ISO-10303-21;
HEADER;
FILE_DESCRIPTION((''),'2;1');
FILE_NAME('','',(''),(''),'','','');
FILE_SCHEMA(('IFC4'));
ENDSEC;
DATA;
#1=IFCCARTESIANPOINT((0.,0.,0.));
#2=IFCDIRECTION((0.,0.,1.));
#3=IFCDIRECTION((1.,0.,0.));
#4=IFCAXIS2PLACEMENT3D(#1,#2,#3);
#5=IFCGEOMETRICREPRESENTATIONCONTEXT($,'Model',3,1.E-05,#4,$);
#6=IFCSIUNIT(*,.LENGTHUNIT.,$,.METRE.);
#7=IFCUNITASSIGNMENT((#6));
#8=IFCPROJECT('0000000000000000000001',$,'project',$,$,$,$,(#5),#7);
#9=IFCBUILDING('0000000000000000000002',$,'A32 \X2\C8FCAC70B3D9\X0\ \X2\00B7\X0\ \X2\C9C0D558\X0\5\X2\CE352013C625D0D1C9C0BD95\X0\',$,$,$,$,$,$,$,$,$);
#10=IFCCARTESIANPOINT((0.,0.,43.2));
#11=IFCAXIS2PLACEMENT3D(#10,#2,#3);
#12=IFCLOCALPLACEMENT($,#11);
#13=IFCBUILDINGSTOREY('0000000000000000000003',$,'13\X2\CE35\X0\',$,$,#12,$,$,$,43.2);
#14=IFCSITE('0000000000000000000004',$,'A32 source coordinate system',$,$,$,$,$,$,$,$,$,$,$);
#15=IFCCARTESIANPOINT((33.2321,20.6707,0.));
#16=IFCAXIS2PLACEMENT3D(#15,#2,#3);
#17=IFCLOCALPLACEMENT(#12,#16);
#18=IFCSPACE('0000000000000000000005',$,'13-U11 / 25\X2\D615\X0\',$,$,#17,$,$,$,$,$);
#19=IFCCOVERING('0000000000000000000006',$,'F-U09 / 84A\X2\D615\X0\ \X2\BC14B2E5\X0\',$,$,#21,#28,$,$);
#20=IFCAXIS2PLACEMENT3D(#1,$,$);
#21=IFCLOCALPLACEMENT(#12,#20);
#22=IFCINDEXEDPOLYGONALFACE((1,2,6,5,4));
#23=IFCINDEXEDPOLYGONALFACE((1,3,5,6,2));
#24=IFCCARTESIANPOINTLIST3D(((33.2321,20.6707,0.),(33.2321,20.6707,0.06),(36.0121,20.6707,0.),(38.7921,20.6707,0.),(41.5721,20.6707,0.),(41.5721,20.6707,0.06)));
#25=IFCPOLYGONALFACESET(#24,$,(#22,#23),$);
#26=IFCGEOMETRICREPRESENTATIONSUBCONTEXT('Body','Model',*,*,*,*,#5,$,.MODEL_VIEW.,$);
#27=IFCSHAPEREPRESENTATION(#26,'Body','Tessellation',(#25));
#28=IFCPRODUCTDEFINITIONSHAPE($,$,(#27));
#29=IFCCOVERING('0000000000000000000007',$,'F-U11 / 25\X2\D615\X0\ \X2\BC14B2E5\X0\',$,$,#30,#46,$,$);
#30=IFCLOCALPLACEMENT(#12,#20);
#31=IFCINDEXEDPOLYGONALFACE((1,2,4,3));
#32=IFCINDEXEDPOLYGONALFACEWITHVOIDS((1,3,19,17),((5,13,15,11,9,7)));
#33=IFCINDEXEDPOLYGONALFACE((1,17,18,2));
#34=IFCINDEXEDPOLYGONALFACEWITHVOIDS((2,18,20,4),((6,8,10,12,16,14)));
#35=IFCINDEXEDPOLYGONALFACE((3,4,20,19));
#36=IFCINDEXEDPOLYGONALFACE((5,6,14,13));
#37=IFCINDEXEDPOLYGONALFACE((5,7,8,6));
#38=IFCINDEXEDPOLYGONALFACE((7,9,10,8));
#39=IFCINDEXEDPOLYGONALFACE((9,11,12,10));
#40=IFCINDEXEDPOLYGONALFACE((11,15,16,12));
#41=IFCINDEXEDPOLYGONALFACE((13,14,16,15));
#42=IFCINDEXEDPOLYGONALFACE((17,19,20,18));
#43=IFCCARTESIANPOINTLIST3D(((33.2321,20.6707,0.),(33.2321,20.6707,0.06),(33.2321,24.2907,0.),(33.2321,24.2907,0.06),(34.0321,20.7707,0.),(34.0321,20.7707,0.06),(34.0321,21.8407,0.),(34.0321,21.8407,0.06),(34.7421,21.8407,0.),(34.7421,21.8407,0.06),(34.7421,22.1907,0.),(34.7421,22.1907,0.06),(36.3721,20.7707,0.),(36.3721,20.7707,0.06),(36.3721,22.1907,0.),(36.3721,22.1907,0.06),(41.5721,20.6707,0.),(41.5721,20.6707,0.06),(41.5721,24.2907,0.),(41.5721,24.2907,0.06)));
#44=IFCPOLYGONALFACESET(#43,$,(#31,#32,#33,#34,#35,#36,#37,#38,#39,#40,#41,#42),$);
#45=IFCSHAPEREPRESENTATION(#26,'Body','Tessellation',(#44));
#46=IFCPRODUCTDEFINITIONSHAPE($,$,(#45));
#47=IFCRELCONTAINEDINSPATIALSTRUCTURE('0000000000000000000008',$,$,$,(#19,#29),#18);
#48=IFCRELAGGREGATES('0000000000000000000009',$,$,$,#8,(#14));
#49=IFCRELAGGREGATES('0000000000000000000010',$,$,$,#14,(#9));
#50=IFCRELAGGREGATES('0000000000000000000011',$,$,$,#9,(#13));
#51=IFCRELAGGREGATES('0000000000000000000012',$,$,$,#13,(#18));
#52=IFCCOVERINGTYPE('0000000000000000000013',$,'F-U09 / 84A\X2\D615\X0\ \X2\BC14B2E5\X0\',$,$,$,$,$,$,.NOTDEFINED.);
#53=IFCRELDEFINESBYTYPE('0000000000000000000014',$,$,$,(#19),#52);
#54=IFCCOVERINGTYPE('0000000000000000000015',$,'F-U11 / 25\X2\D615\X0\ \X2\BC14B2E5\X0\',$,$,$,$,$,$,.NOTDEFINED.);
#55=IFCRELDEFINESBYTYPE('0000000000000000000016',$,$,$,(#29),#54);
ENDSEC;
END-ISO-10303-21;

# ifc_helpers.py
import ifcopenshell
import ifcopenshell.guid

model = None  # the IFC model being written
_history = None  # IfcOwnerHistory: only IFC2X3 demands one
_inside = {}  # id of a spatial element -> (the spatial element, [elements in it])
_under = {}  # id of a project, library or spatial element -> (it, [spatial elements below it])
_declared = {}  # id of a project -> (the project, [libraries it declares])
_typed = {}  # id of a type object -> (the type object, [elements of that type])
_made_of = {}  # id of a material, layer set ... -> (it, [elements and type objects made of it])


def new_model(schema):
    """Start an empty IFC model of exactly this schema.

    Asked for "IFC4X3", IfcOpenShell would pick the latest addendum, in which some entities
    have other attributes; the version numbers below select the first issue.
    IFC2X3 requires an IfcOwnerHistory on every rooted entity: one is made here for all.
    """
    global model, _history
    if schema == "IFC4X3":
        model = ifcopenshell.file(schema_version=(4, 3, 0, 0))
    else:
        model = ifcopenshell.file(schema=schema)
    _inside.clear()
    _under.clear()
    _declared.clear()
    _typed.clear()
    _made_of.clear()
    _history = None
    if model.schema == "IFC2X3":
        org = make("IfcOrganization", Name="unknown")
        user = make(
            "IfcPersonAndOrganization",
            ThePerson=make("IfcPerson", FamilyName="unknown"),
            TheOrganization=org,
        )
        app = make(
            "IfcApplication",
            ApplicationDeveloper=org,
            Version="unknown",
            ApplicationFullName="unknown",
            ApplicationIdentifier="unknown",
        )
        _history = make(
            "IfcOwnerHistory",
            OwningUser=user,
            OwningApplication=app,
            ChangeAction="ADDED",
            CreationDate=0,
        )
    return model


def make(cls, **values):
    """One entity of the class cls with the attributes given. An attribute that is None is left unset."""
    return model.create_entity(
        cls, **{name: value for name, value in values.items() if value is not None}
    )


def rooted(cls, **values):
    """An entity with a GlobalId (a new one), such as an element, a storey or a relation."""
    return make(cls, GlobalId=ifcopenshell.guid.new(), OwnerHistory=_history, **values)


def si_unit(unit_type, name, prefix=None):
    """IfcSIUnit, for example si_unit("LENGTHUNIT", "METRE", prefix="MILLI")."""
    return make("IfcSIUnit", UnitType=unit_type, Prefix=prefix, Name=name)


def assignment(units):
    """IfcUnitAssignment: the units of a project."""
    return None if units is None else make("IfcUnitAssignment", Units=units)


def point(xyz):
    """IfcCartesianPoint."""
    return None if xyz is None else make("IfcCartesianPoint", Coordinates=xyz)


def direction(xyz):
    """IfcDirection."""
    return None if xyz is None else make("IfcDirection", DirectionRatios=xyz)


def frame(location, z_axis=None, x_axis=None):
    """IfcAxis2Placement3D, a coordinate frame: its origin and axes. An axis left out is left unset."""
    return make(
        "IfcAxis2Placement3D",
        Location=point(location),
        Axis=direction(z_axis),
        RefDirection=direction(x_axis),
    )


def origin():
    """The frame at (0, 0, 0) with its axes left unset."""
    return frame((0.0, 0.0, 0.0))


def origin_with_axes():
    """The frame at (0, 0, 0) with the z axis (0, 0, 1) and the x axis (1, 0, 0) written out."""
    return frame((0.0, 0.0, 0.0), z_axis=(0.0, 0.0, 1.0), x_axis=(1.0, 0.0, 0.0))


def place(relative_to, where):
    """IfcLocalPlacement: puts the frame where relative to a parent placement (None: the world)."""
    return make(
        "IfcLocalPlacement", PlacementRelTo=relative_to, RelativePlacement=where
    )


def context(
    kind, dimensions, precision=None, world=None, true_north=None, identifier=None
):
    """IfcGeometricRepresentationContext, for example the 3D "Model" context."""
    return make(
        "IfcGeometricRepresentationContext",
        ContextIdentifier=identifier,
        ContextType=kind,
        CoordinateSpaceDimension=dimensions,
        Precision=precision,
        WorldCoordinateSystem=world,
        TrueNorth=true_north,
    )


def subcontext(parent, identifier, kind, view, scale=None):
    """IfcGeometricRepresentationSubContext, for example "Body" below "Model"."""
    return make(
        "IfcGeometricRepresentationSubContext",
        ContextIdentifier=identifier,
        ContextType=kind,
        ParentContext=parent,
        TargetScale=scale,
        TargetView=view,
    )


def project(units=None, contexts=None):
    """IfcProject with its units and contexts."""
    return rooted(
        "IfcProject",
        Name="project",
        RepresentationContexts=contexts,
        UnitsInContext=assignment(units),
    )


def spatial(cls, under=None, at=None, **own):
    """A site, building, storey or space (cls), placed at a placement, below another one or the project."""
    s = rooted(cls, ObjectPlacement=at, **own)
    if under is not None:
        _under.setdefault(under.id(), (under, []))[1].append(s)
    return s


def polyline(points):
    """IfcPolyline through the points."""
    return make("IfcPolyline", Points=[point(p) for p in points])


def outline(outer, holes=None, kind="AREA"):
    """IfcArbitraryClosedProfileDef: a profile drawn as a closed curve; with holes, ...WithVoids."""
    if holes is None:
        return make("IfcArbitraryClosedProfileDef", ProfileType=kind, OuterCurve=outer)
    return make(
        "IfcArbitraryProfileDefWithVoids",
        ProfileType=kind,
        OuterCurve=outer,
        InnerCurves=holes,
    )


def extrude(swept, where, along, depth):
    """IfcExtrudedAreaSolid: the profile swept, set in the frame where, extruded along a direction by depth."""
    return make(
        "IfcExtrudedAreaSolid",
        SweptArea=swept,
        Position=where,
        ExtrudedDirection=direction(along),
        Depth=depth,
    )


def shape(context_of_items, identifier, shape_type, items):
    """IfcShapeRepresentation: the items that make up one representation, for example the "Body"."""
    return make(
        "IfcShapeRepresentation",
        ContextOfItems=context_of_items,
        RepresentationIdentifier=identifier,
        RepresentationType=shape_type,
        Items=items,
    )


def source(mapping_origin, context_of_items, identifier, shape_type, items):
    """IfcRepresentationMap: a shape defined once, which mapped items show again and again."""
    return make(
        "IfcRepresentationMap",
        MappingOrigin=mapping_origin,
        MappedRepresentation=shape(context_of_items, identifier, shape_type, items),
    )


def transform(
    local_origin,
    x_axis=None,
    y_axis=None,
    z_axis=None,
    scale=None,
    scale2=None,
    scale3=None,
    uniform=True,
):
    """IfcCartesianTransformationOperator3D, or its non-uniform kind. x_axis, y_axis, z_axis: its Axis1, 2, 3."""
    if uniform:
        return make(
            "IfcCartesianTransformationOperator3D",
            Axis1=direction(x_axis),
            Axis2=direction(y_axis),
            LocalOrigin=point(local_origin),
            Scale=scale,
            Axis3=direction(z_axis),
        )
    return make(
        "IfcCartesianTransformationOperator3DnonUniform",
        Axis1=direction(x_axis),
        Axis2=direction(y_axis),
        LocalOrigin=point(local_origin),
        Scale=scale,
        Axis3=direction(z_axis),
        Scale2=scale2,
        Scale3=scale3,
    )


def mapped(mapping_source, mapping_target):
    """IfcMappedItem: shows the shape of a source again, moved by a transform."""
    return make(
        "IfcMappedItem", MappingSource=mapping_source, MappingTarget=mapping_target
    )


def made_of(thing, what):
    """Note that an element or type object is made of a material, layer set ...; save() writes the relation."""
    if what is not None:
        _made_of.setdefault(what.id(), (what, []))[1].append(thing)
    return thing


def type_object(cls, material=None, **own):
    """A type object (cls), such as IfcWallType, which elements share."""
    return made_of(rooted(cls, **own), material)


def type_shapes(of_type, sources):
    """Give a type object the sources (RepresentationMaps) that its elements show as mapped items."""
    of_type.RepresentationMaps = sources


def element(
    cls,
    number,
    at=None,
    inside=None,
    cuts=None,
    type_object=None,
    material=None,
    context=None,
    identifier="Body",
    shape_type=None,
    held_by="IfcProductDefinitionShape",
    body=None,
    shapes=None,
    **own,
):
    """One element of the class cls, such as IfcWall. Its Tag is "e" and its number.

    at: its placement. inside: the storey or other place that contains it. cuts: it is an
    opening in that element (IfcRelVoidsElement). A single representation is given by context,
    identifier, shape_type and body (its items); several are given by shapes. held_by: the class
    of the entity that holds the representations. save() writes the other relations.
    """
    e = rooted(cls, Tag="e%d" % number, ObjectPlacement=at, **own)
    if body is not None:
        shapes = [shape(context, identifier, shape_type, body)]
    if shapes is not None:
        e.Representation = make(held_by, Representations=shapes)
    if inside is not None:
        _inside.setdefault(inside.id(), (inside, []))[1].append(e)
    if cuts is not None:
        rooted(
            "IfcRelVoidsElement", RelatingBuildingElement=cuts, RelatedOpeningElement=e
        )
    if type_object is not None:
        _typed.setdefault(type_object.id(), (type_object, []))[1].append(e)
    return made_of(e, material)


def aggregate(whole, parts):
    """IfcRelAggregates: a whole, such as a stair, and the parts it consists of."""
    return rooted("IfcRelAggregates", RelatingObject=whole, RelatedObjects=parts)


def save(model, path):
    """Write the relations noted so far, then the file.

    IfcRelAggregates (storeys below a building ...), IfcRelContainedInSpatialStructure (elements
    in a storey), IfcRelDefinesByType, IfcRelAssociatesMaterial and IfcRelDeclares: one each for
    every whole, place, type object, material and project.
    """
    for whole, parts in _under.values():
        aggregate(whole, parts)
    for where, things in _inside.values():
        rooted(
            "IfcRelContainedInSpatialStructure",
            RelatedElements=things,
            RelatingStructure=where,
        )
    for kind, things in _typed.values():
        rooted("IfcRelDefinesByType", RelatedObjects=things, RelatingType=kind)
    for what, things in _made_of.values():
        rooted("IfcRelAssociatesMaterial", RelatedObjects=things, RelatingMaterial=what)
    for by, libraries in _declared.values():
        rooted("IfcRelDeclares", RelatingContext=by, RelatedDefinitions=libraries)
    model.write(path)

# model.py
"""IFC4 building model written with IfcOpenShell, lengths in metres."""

from ifc_helpers import new_model, si_unit, frame, origin, origin_with_axes, place, context, subcontext, project, spatial, polyline, outline, extrude, source, transform, mapped, type_object, type_shapes, element, save


model = new_model("IFC4")

# Units and contexts
model_context = context("Model", 3, precision=1e-05, world=origin_with_axes())
body_context = subcontext(model_context, "Body", "Model", "MODEL_VIEW")
ifc_project = project(units=[si_unit("LENGTHUNIT", "METRE")], contexts=[model_context])

# Site, building, storey
site = spatial("IfcSite", under=ifc_project, Name="A32 source coordinate system")
building = spatial("IfcBuilding", under=site, Name="A32 주거동 · 지하5층–옥탑지붕")
storey_placement = place(None, frame((0.0, 0.0, 43.2), z_axis=(0.0, 0.0, 1.0), x_axis=(1.0, 0.0, 0.0)))
storey = spatial("IfcBuildingStorey", under=building, at=storey_placement, Name="13층", Elevation=43.2)

# Shared definitions
space_1_placement = place(storey_placement, frame((33.2321, 20.6707, 0.0), z_axis=(0.0, 0.0, 1.0), x_axis=(1.0, 0.0, 0.0)))
space_1 = spatial("IfcSpace", under=storey, at=space_1_placement, Name="13-U11 / 25형")

# Coverings
covering_type_1 = type_object("IfcCoveringType", Name="F-U09 / 84A형 바닥", PredefinedType="NOTDEFINED")
shared_shape_1 = source(origin(), body_context, "Body", "SweptSolid", [
    extrude(outline(polyline([(0.0, 0.0), (8.34, 0.0), (8.34, 0.0), (0.0, 0.0), (0.0, 0.0)])), origin(), (0.0, 0.0, 1.0), 0.06),
])
type_shapes(covering_type_1, [shared_shape_1])
covering_1_placement = place(space_1_placement, origin_with_axes())
element("IfcCovering", 1, at=covering_1_placement, inside=space_1, type_object=covering_type_1, Name="F-U09 / 84A형 바닥", context=body_context, shape_type="MappedRepresentation", body=[
    mapped(shared_shape_1, transform((0.0, 0.0, 0.0), scale=1.0)),
])
covering_type_2 = type_object("IfcCoveringType", Name="F-U11 / 25형 바닥", PredefinedType="NOTDEFINED")
shared_shape_2 = source(origin(), body_context, "Body", "SweptSolid", [
    extrude(outline(polyline([(0.0, 0.0), (0.0, 3.62), (8.34, 3.62), (8.34, 0.0), (0.0, 0.0)]), holes=[polyline([(1.51, 1.17), (0.8, 1.17), (0.8, 0.1), (3.14, 0.1), (3.14, 1.52), (1.51, 1.52), (1.51, 1.17)])]), origin(), (0.0, 0.0, 1.0), 0.06),
])
type_shapes(covering_type_2, [shared_shape_2])
covering_2_placement = place(space_1_placement, origin_with_axes())
element("IfcCovering", 2, at=covering_2_placement, inside=space_1, type_object=covering_type_2, Name="F-U11 / 25형 바닥", context=body_context, shape_type="MappedRepresentation", body=[
    mapped(shared_shape_2, transform((0.0, 0.0, 0.0), scale=1.0)),
])

save(model, "model.ifc")
